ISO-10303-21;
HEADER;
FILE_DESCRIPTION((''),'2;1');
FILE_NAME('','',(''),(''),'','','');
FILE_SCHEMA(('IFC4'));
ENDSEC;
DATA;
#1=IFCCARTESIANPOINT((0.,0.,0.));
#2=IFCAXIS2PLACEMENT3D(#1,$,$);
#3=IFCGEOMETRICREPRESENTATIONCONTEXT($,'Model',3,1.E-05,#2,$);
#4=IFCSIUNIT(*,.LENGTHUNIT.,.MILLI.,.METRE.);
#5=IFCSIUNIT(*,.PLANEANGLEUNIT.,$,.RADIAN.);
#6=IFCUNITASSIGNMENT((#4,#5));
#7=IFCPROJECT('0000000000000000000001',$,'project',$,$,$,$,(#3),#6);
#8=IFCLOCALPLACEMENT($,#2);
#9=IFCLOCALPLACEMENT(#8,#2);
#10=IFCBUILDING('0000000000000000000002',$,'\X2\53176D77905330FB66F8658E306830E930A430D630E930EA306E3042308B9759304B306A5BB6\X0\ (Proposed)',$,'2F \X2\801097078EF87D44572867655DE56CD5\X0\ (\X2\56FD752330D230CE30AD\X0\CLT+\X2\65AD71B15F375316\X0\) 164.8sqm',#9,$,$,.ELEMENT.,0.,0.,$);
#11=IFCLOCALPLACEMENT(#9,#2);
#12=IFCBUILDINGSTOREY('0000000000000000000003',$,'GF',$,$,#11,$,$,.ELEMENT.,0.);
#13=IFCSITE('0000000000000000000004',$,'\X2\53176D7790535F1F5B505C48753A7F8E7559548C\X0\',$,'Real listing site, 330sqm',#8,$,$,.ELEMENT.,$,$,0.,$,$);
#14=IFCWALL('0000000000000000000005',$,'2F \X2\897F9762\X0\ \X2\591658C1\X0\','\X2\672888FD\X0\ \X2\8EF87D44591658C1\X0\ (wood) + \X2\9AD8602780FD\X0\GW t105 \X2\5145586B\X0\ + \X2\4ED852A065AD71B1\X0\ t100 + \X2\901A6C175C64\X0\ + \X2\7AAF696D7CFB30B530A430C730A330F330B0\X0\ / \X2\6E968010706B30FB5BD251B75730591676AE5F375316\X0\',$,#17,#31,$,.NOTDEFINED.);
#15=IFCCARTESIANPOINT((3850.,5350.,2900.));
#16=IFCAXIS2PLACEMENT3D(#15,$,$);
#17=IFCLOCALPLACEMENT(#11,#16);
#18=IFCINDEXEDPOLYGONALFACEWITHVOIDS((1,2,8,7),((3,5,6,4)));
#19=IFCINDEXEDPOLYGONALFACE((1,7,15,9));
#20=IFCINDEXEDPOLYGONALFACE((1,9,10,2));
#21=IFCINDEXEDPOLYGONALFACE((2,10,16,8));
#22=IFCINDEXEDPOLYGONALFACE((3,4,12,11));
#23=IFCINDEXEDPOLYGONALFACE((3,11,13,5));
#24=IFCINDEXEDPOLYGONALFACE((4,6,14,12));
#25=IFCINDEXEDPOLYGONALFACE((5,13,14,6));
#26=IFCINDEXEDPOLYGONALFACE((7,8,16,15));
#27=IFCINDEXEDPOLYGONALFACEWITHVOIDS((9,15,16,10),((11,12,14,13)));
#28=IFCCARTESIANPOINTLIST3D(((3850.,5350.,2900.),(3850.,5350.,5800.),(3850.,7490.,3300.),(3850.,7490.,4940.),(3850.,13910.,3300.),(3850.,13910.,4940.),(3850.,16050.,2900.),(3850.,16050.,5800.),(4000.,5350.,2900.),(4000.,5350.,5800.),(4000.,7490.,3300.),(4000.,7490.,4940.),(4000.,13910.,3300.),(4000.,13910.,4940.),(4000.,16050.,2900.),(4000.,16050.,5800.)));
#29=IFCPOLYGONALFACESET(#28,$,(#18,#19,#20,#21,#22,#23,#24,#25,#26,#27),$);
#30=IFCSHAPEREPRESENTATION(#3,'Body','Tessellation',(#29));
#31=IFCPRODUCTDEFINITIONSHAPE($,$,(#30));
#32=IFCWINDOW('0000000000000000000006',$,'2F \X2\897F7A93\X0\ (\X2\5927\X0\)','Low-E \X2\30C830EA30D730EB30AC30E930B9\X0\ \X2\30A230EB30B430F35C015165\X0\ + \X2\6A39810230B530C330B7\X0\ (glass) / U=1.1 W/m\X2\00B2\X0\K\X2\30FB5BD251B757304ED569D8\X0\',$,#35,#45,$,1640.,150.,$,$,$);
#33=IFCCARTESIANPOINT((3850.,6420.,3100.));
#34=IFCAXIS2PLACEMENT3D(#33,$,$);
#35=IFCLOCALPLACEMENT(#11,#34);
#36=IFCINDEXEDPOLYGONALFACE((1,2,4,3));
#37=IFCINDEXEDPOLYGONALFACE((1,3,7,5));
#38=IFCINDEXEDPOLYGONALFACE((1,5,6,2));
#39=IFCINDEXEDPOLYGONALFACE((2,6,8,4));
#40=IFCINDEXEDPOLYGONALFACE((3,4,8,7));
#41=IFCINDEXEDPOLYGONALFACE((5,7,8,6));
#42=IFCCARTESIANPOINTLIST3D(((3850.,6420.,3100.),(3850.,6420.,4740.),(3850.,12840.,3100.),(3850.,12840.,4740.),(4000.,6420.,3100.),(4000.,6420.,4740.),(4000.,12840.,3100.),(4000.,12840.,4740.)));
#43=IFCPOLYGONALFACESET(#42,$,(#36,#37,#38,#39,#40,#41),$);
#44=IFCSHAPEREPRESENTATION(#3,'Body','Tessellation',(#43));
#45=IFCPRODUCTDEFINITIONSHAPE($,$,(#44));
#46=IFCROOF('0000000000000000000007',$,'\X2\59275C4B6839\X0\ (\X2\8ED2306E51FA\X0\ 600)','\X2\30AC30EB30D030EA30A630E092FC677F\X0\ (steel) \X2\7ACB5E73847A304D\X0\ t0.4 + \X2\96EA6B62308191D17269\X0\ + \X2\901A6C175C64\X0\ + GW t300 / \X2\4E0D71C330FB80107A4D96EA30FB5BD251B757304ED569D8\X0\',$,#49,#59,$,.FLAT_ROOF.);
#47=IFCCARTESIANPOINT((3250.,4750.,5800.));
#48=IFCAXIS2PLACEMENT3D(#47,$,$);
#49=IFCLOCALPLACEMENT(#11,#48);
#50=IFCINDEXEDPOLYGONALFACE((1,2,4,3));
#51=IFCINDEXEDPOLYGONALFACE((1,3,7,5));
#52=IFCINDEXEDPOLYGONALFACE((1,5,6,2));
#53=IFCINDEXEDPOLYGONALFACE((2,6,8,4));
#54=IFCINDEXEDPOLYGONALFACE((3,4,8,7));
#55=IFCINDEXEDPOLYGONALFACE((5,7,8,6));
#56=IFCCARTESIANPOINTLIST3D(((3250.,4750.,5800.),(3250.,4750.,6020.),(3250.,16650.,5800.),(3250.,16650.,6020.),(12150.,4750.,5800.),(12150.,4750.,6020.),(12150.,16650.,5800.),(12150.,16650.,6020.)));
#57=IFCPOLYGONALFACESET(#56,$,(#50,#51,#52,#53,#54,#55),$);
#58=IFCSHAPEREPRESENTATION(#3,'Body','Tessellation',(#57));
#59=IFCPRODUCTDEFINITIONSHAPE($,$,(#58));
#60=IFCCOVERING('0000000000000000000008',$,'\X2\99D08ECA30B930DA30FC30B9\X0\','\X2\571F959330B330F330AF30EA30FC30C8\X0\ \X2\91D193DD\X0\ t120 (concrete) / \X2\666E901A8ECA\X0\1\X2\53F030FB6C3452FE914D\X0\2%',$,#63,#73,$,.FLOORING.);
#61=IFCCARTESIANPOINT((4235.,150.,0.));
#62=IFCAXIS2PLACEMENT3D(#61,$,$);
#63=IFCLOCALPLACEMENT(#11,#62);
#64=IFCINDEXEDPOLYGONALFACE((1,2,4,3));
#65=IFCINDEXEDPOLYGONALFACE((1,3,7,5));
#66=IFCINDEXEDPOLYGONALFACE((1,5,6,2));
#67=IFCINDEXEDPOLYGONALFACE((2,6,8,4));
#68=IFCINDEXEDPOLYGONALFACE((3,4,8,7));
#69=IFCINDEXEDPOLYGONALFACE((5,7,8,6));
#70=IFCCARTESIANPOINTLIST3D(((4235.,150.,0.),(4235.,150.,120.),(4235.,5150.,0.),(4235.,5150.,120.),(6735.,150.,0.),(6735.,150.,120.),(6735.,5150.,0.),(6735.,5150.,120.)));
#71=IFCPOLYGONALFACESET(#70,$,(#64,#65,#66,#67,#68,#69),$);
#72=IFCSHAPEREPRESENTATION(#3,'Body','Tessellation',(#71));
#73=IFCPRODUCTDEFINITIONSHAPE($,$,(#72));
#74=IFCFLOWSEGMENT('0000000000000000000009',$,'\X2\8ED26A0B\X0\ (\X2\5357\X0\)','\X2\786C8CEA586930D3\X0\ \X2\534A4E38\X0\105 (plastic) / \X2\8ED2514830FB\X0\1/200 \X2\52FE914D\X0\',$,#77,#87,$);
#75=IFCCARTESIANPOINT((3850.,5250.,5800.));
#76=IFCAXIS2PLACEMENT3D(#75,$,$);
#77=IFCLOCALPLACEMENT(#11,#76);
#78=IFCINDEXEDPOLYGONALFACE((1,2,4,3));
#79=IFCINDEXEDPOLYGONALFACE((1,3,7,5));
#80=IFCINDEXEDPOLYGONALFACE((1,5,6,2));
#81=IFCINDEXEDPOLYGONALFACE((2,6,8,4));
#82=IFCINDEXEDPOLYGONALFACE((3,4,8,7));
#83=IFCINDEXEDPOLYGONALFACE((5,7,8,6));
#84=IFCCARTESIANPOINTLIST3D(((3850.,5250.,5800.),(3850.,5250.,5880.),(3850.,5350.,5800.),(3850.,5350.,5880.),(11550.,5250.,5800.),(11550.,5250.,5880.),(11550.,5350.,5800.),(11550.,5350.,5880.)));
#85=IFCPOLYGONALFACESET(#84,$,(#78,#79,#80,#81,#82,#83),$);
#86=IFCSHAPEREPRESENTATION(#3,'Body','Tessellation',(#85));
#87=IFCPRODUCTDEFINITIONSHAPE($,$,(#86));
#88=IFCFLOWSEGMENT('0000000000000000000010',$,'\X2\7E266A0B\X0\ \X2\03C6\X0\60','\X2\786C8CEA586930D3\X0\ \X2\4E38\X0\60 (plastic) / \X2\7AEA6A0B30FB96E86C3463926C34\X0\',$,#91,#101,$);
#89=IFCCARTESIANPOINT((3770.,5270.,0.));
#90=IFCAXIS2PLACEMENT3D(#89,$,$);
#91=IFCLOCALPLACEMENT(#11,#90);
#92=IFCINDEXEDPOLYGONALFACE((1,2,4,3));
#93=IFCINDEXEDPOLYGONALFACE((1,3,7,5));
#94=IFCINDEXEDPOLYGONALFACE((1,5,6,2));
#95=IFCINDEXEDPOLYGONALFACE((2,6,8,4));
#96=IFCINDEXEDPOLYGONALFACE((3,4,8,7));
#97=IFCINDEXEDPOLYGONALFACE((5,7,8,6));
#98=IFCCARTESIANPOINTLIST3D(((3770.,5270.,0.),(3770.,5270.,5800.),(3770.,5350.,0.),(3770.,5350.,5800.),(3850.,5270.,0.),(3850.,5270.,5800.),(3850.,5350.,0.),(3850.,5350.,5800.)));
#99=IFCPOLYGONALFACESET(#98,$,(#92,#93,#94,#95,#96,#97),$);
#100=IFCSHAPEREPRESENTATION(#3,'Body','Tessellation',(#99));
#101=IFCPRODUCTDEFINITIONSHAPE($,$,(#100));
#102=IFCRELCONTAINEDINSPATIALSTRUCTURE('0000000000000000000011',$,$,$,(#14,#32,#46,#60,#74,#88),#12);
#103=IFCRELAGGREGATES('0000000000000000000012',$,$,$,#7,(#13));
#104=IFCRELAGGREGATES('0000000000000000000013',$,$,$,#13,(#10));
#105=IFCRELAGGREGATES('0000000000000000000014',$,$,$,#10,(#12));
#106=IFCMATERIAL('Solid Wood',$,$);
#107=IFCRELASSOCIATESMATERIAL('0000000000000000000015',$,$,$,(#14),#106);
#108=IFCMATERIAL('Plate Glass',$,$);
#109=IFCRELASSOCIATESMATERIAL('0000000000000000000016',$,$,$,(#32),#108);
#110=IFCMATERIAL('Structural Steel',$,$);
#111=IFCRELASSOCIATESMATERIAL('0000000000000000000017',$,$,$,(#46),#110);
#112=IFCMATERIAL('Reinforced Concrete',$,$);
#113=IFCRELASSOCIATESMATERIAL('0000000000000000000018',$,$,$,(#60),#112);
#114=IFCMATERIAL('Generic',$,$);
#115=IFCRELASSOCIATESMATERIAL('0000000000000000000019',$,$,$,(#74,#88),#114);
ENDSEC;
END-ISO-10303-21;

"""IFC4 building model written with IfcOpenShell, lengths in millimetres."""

from ifc_helpers import new_model, si_unit, frame, frame_2d, origin, place, context, project, spatial, rectangle, extrude, material, element, fill, save


model = new_model("IFC4")

# Units and contexts
model_context = context("Model", 3, precision=1e-05, world=origin())
ifc_project = project(units=[si_unit("LENGTHUNIT", "METRE", prefix="MILLI"), si_unit("PLANEANGLEUNIT", "RADIAN")], contexts=[model_context])

# Site, building, storey
site_placement = place(None, origin())
site = spatial("IfcSite", under=ifc_project, at=site_placement, Name="北海道弟子屈町美留和", ObjectType="Real listing site, 330sqm", CompositionType="ELEMENT", RefElevation=0.0)
building_placement = place(site_placement, origin())
building = spatial("IfcBuilding", under=site, at=building_placement, Name="北海道・書斎とライブラリのある静かな家 (Proposed)", ObjectType="2F 耐震軸組在来工法 (国産ヒノキCLT+断熱強化) 164.8sqm", CompositionType="ELEMENT", ElevationOfRefHeight=0.0, ElevationOfTerrain=0.0)
storey_placement = place(building_placement, origin())
storey = spatial("IfcBuildingStorey", under=building, at=storey_placement, Name="GF", CompositionType="ELEMENT", Elevation=0.0)

# Shared definitions
ifc_material_1 = material(Name="Solid Wood")

# Shared definitions
ifc_material_2 = material(Name="Reinforced Concrete")

# Shared definitions
ifc_material_3 = material(Name="Plate Glass")

# Wall, opening, window
wall_1_placement = place(storey_placement, frame((3850.0, 5350.0, 2900.0)))
wall_1 = element("IfcWall", 1, at=wall_1_placement, inside=storey, material=ifc_material_1, Name="2F 西面 外壁", Description="木製 軸組外壁 (wood) + 高性能GW t105 充填 + 付加断熱 t100 + 通気層 + 窯業系サイディング / 準耐火・寒冷地外皮強化", PredefinedType="NOTDEFINED", context=model_context, shape_type="SweptSolid", body=[
    extrude(rectangle(XDim=150.0, YDim=10700.0, at=frame_2d((75.0, 5350.0))), frame((3850.0, 5350.0, 2900.0)), (0.0, 0.0, 1.0), 2900.0),
])
opening_1_placement = place(storey_placement, frame((3850.0, 6420.0, 3100.0)))
opening_1 = element("IfcOpeningElement", 2, at=opening_1_placement, cuts=wall_1, PredefinedType="NOTDEFINED", context=model_context, shape_type="SweptSolid", body=[
    extrude(rectangle(XDim=150.0, YDim=6420.0, at=frame_2d((75.0, 3210.0))), frame((3850.0, 6420.0, 3100.0)), (0.0, 0.0, 1.0), 1640.0),
])
window_1_placement = place(storey_placement, frame((3850.0, 6420.0, 3100.0)))
window_1 = element("IfcWindow", 3, at=window_1_placement, inside=storey, material=ifc_material_3, Name="2F 西窓 (大)", Description="Low-E トリプルガラス アルゴン封入 + 樹脂サッシ (glass) / U=1.1 W/m²K・寒冷地仕様", OverallHeight=1640.0, OverallWidth=150.0, context=model_context, shape_type="SweptSolid", body=[
    extrude(rectangle(XDim=150.0, YDim=6420.0, at=frame_2d((75.0, 3210.0))), frame((3850.0, 6420.0, 3100.0)), (0.0, 0.0, 1.0), 1640.0),
])
fill(opening_1, window_1)

# Roof
ifc_material_4 = material(Name="Structural Steel")
roof_placement = place(storey_placement, frame((3250.0, 4750.0, 5800.0)))
element("IfcRoof", 4, at=roof_placement, inside=storey, material=ifc_material_4, Name="大屋根 (軒の出 600)", Description="ガルバリウム鋼板 (steel) 立平葺き t0.4 + 雪止め金物 + 通気層 + GW t300 / 不燃・耐積雪・寒冷地仕様", PredefinedType="FLAT_ROOF", context=model_context, shape_type="SweptSolid", body=[
    extrude(rectangle(XDim=8900.0, YDim=11900.0, at=frame_2d((4450.0, 5950.0))), frame((3250.0, 4750.0, 5800.0)), (0.0, 0.0, 1.0), 220.0),
])

# Covering
covering_placement = place(storey_placement, frame((4235.0, 150.0, 0.0)))
element("IfcCovering", 5, at=covering_placement, inside=storey, material=ifc_material_2, Name="駐車スペース", Description="土間コンクリート 金鏝 t120 (concrete) / 普通車1台・水勾配2%", PredefinedType="FLOORING", context=model_context, shape_type="SweptSolid", body=[
    extrude(rectangle(XDim=2500.0, YDim=5000.0, at=frame_2d((1250.0, 2500.0))), frame((4235.0, 150.0, 0.0)), (0.0, 0.0, 1.0), 120.0),
])

# Flow segments
ifc_material_5 = material(Name="Generic")
flow_segment_1_placement = place(storey_placement, frame((3850.0, 5250.0, 5800.0)))
element("IfcFlowSegment", 6, at=flow_segment_1_placement, inside=storey, material=ifc_material_5, Name="軒樋 (南)", Description="硬質塩ビ 半丸105 (plastic) / 軒先・1/200 勾配", context=model_context, shape_type="SweptSolid", body=[
    extrude(rectangle(XDim=7700.0, YDim=100.0, at=frame_2d((3850.0, 50.0))), frame((3850.0, 5250.0, 5800.0)), (0.0, 0.0, 1.0), 80.0),
])
flow_segment_2_placement = place(storey_placement, frame((3770.0, 5270.0, 0.0)))
element("IfcFlowSegment", 7, at=flow_segment_2_placement, inside=storey, material=ifc_material_5, Name="縦樋 φ60", Description="硬質塩ビ 丸60 (plastic) / 竪樋・雨水排水", context=model_context, shape_type="SweptSolid", body=[
    extrude(rectangle(XDim=80.0, YDim=80.0, at=frame_2d((40.0, 40.0))), frame((3770.0, 5270.0, 0.0)), (0.0, 0.0, 1.0), 5800.0),
])

save(model, "model.ifc")
